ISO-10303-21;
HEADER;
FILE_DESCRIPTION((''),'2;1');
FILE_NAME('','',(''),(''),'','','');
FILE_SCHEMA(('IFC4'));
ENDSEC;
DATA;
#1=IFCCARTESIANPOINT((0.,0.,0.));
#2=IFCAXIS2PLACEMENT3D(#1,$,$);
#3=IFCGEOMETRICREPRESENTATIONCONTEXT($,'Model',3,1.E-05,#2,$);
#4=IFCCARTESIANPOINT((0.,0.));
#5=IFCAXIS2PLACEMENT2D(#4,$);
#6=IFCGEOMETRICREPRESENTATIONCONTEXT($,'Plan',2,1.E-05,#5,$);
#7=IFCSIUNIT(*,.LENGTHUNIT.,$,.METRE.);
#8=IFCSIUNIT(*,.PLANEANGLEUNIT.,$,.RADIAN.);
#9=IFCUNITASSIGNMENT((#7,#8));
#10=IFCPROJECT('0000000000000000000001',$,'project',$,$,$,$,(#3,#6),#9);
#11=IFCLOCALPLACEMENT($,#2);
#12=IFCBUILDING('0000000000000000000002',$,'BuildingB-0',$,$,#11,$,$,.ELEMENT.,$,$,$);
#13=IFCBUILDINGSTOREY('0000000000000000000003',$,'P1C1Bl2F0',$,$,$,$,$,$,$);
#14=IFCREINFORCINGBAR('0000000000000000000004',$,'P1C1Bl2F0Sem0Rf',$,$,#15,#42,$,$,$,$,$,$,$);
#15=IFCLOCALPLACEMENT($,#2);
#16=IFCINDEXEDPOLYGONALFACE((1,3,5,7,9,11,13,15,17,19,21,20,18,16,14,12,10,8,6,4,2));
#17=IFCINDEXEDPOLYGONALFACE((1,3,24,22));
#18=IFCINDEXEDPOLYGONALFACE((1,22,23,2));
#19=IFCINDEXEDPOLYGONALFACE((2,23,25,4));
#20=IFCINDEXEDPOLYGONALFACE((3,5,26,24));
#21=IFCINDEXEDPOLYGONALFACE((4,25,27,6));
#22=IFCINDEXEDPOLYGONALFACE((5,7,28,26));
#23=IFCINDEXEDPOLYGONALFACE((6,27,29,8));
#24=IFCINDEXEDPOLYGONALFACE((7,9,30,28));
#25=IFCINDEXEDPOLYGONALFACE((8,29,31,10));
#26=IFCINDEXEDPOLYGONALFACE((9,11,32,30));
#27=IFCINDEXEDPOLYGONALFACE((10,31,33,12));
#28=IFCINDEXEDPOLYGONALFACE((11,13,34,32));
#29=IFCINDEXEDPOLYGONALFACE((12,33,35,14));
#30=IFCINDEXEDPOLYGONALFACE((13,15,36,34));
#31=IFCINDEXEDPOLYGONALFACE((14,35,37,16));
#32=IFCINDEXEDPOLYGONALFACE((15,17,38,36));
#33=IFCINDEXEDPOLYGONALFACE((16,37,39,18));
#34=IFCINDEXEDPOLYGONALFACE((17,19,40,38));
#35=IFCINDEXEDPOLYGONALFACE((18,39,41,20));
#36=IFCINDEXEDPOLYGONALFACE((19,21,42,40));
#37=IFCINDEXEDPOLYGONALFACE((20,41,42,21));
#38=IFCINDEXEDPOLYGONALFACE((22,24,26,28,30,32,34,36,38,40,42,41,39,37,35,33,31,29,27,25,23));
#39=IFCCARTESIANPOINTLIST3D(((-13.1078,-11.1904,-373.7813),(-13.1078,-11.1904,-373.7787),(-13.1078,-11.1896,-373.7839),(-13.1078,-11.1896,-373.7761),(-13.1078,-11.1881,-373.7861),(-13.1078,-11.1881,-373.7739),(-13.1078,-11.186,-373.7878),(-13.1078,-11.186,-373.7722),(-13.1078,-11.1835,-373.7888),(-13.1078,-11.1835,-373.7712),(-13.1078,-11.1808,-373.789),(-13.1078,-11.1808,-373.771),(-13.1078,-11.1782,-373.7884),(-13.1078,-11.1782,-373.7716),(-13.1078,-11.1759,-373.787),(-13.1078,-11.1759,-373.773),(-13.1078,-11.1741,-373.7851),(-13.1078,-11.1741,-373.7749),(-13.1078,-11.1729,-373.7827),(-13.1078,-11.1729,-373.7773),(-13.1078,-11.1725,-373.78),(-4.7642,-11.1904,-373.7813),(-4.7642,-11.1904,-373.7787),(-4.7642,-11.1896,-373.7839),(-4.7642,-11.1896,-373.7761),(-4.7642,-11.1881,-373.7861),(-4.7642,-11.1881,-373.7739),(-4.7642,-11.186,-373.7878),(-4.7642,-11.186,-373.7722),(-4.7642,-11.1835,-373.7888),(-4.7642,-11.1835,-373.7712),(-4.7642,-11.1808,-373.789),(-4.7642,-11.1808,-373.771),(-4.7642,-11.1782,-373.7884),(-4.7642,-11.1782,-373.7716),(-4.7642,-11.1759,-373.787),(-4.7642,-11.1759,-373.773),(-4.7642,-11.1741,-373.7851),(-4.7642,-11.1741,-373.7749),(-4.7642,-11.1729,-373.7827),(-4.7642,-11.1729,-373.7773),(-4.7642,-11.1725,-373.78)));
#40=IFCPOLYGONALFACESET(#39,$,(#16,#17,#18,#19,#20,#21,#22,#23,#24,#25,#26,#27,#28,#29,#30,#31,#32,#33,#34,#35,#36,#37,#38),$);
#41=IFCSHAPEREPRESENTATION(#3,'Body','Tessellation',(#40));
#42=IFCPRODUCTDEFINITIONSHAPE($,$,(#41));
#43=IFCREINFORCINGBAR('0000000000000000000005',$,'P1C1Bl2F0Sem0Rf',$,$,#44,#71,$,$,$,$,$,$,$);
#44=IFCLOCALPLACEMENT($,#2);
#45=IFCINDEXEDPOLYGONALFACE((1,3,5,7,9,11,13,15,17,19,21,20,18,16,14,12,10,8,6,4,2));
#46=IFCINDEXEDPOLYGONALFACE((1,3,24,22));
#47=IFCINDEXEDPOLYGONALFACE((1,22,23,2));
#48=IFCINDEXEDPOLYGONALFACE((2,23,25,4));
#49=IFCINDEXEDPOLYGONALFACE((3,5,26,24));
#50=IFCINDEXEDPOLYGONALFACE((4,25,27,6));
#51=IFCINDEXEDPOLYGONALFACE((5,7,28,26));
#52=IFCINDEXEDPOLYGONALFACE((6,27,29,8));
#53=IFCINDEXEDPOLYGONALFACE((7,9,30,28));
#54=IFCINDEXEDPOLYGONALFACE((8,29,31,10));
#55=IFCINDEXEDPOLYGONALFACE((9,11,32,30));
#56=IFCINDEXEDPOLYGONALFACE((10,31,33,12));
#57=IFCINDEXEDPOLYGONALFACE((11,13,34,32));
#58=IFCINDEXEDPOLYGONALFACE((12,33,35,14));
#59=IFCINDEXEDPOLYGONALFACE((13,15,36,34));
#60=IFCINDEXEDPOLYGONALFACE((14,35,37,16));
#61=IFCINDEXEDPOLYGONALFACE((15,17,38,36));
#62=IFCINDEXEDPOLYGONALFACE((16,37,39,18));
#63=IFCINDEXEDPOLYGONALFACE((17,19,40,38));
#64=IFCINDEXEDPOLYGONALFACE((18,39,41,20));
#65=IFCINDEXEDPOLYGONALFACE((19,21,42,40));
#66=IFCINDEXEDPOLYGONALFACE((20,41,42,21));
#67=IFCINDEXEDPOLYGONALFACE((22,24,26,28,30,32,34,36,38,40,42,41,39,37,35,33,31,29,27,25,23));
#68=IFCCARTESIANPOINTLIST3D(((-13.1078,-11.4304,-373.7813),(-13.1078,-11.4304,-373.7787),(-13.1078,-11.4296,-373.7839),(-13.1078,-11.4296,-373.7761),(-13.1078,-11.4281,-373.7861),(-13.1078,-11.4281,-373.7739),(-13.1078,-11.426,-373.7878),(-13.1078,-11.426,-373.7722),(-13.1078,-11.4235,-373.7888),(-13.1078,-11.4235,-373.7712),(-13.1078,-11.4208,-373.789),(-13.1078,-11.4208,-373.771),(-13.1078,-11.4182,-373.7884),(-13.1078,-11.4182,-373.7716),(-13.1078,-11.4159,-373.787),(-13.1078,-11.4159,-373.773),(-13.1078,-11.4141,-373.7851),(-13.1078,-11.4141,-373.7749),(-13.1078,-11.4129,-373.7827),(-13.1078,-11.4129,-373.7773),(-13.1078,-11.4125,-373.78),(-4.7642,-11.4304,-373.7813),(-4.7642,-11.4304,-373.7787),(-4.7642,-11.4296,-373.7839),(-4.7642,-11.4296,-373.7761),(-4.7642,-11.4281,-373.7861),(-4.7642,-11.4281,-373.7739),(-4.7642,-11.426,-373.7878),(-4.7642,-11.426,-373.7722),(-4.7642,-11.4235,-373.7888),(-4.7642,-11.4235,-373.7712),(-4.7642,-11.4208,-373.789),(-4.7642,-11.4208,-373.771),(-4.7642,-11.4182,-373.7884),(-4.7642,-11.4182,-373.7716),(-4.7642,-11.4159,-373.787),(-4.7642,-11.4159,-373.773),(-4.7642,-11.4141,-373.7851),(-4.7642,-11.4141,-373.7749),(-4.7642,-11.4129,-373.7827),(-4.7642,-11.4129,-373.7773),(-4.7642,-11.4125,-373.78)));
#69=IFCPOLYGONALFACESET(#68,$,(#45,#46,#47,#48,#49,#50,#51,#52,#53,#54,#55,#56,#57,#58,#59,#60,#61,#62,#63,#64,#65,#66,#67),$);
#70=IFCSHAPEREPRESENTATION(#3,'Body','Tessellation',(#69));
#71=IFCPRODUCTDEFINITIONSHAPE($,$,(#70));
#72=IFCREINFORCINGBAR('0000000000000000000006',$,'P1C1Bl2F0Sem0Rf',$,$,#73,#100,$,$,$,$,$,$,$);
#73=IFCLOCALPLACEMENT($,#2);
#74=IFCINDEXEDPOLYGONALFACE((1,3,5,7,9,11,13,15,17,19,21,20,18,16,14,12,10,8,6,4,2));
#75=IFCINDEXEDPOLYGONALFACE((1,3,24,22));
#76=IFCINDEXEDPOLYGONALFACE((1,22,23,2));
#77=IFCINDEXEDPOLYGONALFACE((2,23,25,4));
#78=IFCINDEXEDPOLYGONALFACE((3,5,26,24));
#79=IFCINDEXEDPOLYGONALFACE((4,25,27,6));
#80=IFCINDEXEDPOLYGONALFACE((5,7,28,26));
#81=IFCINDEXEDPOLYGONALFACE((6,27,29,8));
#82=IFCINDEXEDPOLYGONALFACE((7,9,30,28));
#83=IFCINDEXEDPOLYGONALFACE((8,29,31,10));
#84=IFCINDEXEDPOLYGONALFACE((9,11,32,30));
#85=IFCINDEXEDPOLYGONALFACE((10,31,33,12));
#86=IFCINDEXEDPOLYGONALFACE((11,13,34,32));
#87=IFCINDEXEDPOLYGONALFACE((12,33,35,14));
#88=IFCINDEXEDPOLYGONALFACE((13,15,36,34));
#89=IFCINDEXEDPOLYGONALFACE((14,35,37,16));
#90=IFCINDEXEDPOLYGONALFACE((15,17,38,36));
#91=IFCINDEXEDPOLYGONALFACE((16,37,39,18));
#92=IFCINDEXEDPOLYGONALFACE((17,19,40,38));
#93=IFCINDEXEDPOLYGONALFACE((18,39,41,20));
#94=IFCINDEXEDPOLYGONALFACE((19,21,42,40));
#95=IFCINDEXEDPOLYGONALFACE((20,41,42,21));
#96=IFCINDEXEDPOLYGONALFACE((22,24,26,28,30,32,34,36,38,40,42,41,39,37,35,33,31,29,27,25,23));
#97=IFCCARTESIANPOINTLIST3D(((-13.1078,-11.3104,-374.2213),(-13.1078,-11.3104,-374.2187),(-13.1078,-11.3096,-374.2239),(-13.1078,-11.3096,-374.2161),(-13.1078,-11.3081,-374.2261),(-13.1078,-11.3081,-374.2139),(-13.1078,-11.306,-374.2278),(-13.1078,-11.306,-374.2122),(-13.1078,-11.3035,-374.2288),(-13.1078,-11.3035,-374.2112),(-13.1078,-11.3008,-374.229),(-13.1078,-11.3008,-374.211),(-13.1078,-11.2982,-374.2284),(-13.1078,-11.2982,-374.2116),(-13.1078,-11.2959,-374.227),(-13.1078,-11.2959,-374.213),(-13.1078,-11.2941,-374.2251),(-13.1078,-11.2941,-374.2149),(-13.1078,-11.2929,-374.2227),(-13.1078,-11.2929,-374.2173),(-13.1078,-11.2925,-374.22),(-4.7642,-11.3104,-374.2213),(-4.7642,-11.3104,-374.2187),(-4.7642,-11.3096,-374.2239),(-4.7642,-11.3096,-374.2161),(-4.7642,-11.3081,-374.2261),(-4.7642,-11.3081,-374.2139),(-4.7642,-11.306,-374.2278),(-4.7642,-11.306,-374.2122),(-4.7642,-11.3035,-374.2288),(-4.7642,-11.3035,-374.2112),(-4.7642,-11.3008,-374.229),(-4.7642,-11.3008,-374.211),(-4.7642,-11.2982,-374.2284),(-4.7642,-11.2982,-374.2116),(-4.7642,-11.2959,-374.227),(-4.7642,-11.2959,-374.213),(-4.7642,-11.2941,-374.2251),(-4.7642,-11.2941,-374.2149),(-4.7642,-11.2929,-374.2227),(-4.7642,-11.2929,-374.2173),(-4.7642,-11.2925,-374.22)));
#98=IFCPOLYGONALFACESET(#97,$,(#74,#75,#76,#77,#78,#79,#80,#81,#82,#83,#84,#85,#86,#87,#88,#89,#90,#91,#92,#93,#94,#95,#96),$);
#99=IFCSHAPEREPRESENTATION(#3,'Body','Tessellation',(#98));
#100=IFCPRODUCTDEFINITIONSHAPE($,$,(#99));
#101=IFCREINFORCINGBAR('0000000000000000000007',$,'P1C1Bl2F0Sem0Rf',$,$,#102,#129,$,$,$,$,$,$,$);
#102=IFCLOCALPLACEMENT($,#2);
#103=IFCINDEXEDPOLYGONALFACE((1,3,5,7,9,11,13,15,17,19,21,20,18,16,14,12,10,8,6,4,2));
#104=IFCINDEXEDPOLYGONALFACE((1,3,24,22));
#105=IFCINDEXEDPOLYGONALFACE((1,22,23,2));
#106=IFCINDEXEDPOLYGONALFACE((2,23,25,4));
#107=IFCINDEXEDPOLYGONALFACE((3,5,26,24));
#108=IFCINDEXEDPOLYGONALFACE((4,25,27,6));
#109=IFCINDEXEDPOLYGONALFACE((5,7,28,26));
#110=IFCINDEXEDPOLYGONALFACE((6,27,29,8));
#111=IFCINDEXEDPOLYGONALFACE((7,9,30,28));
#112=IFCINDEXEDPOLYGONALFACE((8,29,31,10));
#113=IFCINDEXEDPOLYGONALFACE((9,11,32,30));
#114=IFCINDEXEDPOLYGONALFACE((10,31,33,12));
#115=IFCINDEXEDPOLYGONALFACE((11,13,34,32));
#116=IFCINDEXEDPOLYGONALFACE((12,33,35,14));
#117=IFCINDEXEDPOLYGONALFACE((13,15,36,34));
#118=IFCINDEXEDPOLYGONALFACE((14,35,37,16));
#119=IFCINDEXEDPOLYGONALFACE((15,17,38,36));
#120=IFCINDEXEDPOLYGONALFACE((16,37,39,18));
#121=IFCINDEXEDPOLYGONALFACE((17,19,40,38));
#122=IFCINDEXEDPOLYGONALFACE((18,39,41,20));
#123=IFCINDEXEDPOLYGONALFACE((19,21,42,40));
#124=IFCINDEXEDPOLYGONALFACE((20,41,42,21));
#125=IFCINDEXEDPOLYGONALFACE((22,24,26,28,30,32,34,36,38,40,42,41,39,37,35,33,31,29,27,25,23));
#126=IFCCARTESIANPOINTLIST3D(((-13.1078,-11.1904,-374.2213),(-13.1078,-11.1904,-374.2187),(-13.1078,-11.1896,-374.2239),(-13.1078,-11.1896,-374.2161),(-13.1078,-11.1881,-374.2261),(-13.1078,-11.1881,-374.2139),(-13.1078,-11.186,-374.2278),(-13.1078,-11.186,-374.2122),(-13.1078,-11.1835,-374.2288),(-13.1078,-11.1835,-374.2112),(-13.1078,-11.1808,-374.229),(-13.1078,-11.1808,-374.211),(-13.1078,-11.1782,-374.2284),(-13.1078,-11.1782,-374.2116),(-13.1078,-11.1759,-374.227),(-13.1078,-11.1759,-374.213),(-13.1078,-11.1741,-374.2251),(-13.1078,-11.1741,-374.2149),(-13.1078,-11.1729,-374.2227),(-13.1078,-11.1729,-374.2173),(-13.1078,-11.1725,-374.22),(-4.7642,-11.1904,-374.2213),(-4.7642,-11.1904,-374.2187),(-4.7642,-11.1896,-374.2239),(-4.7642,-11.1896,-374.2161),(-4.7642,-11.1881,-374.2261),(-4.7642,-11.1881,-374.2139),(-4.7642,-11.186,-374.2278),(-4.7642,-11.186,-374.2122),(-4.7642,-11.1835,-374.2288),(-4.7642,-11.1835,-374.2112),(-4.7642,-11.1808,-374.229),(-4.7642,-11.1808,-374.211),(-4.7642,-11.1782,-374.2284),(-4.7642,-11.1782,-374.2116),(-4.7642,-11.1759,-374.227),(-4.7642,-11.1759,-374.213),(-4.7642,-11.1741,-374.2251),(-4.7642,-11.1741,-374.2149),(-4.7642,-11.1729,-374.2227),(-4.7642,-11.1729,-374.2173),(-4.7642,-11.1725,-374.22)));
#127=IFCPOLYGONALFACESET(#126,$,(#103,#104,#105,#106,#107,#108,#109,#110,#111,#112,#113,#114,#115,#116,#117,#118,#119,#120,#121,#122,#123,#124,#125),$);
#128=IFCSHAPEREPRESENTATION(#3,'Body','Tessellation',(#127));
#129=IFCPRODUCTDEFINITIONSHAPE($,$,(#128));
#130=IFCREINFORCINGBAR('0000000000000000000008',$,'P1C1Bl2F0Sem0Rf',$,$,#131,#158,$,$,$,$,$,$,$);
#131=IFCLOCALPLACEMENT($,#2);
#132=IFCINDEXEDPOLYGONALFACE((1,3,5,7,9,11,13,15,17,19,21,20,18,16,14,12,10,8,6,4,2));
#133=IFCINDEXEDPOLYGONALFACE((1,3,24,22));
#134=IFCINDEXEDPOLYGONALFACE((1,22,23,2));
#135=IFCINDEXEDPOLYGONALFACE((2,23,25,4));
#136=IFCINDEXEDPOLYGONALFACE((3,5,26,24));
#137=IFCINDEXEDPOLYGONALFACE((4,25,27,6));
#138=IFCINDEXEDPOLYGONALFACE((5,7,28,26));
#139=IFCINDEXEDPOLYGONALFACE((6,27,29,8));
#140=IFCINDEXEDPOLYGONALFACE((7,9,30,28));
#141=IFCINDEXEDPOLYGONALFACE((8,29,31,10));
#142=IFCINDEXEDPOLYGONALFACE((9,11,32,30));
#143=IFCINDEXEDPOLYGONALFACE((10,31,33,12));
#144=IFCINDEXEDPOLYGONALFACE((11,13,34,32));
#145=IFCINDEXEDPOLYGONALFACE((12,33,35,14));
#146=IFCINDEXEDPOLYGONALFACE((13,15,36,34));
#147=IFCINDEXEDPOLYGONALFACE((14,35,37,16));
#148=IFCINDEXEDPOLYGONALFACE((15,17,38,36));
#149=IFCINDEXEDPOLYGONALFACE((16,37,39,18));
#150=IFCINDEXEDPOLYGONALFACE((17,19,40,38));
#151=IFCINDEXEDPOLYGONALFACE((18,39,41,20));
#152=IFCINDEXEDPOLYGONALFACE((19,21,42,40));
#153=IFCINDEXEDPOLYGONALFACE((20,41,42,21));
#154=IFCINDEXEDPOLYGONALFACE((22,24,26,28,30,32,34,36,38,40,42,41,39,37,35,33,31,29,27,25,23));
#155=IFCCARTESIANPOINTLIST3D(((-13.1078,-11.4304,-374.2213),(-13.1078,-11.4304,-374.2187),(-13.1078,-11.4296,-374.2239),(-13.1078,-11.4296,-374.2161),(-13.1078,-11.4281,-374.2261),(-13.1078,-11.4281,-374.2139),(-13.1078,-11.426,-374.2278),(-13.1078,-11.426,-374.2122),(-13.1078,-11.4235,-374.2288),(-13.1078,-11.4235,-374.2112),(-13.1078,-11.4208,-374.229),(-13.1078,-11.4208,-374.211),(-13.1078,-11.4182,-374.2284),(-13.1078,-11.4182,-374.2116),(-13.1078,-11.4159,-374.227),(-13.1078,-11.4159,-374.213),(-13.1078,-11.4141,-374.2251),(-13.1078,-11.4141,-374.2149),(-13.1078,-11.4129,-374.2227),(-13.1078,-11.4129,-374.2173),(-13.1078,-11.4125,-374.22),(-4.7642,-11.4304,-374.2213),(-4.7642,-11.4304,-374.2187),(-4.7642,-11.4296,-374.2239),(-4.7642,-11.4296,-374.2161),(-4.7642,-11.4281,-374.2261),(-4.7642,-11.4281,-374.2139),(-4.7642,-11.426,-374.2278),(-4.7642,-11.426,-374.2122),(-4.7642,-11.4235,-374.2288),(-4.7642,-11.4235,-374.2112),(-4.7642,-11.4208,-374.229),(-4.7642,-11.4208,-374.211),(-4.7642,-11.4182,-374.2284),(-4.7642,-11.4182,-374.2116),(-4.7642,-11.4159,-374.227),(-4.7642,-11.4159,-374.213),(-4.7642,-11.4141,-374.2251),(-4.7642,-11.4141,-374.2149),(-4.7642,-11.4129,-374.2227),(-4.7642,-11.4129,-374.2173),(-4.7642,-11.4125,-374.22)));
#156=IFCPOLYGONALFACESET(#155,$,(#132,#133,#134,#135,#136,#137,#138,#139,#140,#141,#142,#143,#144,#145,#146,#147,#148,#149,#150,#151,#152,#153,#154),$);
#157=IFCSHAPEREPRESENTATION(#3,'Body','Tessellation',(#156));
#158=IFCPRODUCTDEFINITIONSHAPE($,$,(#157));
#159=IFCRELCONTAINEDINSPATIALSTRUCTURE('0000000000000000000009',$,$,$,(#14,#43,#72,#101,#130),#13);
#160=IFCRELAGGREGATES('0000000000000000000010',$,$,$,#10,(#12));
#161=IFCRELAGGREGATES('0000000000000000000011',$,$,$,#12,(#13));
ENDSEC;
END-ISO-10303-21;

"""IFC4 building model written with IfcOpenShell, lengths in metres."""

from ifc_helpers import new_model, entity, si_unit, origin, origin_2d, place, context, project, spatial, element, save


model = new_model("IFC4")

# Units and contexts
model_context = context("Model", 3, precision=1e-05, world=origin())
plan_context = context("Plan", 2, precision=1e-05, world=origin_2d())
ifc_project = project(units=[si_unit("LENGTHUNIT", "METRE"), si_unit("PLANEANGLEUNIT", "RADIAN")], contexts=[model_context, plan_context])

# Building, storey
building_placement = place(None, origin())
building = spatial("IfcBuilding", under=ifc_project, at=building_placement, Name="BuildingB-0", CompositionType="ELEMENT")
storey = spatial("IfcBuildingStorey", under=building, Name="P1C1Bl2F0")

# Reinforcing bars
element("IfcReinforcingBar", 1, inside=storey, Name="P1C1Bl2F0Sem0Rf", context=model_context, shape_type="SweptSolid", body=[
    entity("IfcSurfaceCurveSweptAreaSolid", entity("IfcCircleProfileDef", "AREA", None, None, 0.009), None, entity("IfcPolyline", [entity("IfcCartesianPoint", [4.7642, 11.1815, 373.78]), entity("IfcCartesianPoint", [13.1078, 11.1815, 373.78])]), None, None, entity("IfcPlane", entity("IfcAxis2Placement3D", entity("IfcCartesianPoint", [4.7642, 11.1815, 373.78]), entity("IfcDirection", [0.0, 0.0, 1.0]), entity("IfcDirection", [1.0, 0.0, 0.0])))),
])
element("IfcReinforcingBar", 2, inside=storey, Name="P1C1Bl2F0Sem0Rf", context=model_context, shape_type="SweptSolid", body=[
    entity("IfcSurfaceCurveSweptAreaSolid", entity("IfcCircleProfileDef", "AREA", None, None, 0.009), None, entity("IfcPolyline", [entity("IfcCartesianPoint", [4.7642, 11.4215, 373.78]), entity("IfcCartesianPoint", [13.1078, 11.4215, 373.78])]), None, None, entity("IfcPlane", entity("IfcAxis2Placement3D", entity("IfcCartesianPoint", [4.7642, 11.4215, 373.78]), entity("IfcDirection", [0.0, 0.0, 1.0]), entity("IfcDirection", [1.0, 0.0, 0.0])))),
])
element("IfcReinforcingBar", 3, inside=storey, Name="P1C1Bl2F0Sem0Rf", context=model_context, shape_type="SweptSolid", body=[
    entity("IfcSurfaceCurveSweptAreaSolid", entity("IfcCircleProfileDef", "AREA", None, None, 0.009), None, entity("IfcPolyline", [entity("IfcCartesianPoint", [4.7642, 11.3015, 374.22]), entity("IfcCartesianPoint", [13.1078, 11.3015, 374.22])]), None, None, entity("IfcPlane", entity("IfcAxis2Placement3D", entity("IfcCartesianPoint", [4.7642, 11.3015, 374.22]), entity("IfcDirection", [0.0, 0.0, 1.0]), entity("IfcDirection", [1.0, 0.0, 0.0])))),
])
element("IfcReinforcingBar", 4, inside=storey, Name="P1C1Bl2F0Sem0Rf", context=model_context, shape_type="SweptSolid", body=[
    entity("IfcSurfaceCurveSweptAreaSolid", entity("IfcCircleProfileDef", "AREA", None, None, 0.009), None, entity("IfcPolyline", [entity("IfcCartesianPoint", [4.7642, 11.1815, 374.22]), entity("IfcCartesianPoint", [13.1078, 11.1815, 374.22])]), None, None, entity("IfcPlane", entity("IfcAxis2Placement3D", entity("IfcCartesianPoint", [4.7642, 11.1815, 374.22]), entity("IfcDirection", [0.0, 0.0, 1.0]), entity("IfcDirection", [1.0, 0.0, 0.0])))),
])
element("IfcReinforcingBar", 5, inside=storey, Name="P1C1Bl2F0Sem0Rf", context=model_context, shape_type="SweptSolid", body=[
    entity("IfcSurfaceCurveSweptAreaSolid", entity("IfcCircleProfileDef", "AREA", None, None, 0.009), None, entity("IfcPolyline", [entity("IfcCartesianPoint", [4.7642, 11.4215, 374.22]), entity("IfcCartesianPoint", [13.1078, 11.4215, 374.22])]), None, None, entity("IfcPlane", entity("IfcAxis2Placement3D", entity("IfcCartesianPoint", [4.7642, 11.4215, 374.22]), entity("IfcDirection", [0.0, 0.0, 1.0]), entity("IfcDirection", [1.0, 0.0, 0.0])))),
])

save(model, "model.ifc")
